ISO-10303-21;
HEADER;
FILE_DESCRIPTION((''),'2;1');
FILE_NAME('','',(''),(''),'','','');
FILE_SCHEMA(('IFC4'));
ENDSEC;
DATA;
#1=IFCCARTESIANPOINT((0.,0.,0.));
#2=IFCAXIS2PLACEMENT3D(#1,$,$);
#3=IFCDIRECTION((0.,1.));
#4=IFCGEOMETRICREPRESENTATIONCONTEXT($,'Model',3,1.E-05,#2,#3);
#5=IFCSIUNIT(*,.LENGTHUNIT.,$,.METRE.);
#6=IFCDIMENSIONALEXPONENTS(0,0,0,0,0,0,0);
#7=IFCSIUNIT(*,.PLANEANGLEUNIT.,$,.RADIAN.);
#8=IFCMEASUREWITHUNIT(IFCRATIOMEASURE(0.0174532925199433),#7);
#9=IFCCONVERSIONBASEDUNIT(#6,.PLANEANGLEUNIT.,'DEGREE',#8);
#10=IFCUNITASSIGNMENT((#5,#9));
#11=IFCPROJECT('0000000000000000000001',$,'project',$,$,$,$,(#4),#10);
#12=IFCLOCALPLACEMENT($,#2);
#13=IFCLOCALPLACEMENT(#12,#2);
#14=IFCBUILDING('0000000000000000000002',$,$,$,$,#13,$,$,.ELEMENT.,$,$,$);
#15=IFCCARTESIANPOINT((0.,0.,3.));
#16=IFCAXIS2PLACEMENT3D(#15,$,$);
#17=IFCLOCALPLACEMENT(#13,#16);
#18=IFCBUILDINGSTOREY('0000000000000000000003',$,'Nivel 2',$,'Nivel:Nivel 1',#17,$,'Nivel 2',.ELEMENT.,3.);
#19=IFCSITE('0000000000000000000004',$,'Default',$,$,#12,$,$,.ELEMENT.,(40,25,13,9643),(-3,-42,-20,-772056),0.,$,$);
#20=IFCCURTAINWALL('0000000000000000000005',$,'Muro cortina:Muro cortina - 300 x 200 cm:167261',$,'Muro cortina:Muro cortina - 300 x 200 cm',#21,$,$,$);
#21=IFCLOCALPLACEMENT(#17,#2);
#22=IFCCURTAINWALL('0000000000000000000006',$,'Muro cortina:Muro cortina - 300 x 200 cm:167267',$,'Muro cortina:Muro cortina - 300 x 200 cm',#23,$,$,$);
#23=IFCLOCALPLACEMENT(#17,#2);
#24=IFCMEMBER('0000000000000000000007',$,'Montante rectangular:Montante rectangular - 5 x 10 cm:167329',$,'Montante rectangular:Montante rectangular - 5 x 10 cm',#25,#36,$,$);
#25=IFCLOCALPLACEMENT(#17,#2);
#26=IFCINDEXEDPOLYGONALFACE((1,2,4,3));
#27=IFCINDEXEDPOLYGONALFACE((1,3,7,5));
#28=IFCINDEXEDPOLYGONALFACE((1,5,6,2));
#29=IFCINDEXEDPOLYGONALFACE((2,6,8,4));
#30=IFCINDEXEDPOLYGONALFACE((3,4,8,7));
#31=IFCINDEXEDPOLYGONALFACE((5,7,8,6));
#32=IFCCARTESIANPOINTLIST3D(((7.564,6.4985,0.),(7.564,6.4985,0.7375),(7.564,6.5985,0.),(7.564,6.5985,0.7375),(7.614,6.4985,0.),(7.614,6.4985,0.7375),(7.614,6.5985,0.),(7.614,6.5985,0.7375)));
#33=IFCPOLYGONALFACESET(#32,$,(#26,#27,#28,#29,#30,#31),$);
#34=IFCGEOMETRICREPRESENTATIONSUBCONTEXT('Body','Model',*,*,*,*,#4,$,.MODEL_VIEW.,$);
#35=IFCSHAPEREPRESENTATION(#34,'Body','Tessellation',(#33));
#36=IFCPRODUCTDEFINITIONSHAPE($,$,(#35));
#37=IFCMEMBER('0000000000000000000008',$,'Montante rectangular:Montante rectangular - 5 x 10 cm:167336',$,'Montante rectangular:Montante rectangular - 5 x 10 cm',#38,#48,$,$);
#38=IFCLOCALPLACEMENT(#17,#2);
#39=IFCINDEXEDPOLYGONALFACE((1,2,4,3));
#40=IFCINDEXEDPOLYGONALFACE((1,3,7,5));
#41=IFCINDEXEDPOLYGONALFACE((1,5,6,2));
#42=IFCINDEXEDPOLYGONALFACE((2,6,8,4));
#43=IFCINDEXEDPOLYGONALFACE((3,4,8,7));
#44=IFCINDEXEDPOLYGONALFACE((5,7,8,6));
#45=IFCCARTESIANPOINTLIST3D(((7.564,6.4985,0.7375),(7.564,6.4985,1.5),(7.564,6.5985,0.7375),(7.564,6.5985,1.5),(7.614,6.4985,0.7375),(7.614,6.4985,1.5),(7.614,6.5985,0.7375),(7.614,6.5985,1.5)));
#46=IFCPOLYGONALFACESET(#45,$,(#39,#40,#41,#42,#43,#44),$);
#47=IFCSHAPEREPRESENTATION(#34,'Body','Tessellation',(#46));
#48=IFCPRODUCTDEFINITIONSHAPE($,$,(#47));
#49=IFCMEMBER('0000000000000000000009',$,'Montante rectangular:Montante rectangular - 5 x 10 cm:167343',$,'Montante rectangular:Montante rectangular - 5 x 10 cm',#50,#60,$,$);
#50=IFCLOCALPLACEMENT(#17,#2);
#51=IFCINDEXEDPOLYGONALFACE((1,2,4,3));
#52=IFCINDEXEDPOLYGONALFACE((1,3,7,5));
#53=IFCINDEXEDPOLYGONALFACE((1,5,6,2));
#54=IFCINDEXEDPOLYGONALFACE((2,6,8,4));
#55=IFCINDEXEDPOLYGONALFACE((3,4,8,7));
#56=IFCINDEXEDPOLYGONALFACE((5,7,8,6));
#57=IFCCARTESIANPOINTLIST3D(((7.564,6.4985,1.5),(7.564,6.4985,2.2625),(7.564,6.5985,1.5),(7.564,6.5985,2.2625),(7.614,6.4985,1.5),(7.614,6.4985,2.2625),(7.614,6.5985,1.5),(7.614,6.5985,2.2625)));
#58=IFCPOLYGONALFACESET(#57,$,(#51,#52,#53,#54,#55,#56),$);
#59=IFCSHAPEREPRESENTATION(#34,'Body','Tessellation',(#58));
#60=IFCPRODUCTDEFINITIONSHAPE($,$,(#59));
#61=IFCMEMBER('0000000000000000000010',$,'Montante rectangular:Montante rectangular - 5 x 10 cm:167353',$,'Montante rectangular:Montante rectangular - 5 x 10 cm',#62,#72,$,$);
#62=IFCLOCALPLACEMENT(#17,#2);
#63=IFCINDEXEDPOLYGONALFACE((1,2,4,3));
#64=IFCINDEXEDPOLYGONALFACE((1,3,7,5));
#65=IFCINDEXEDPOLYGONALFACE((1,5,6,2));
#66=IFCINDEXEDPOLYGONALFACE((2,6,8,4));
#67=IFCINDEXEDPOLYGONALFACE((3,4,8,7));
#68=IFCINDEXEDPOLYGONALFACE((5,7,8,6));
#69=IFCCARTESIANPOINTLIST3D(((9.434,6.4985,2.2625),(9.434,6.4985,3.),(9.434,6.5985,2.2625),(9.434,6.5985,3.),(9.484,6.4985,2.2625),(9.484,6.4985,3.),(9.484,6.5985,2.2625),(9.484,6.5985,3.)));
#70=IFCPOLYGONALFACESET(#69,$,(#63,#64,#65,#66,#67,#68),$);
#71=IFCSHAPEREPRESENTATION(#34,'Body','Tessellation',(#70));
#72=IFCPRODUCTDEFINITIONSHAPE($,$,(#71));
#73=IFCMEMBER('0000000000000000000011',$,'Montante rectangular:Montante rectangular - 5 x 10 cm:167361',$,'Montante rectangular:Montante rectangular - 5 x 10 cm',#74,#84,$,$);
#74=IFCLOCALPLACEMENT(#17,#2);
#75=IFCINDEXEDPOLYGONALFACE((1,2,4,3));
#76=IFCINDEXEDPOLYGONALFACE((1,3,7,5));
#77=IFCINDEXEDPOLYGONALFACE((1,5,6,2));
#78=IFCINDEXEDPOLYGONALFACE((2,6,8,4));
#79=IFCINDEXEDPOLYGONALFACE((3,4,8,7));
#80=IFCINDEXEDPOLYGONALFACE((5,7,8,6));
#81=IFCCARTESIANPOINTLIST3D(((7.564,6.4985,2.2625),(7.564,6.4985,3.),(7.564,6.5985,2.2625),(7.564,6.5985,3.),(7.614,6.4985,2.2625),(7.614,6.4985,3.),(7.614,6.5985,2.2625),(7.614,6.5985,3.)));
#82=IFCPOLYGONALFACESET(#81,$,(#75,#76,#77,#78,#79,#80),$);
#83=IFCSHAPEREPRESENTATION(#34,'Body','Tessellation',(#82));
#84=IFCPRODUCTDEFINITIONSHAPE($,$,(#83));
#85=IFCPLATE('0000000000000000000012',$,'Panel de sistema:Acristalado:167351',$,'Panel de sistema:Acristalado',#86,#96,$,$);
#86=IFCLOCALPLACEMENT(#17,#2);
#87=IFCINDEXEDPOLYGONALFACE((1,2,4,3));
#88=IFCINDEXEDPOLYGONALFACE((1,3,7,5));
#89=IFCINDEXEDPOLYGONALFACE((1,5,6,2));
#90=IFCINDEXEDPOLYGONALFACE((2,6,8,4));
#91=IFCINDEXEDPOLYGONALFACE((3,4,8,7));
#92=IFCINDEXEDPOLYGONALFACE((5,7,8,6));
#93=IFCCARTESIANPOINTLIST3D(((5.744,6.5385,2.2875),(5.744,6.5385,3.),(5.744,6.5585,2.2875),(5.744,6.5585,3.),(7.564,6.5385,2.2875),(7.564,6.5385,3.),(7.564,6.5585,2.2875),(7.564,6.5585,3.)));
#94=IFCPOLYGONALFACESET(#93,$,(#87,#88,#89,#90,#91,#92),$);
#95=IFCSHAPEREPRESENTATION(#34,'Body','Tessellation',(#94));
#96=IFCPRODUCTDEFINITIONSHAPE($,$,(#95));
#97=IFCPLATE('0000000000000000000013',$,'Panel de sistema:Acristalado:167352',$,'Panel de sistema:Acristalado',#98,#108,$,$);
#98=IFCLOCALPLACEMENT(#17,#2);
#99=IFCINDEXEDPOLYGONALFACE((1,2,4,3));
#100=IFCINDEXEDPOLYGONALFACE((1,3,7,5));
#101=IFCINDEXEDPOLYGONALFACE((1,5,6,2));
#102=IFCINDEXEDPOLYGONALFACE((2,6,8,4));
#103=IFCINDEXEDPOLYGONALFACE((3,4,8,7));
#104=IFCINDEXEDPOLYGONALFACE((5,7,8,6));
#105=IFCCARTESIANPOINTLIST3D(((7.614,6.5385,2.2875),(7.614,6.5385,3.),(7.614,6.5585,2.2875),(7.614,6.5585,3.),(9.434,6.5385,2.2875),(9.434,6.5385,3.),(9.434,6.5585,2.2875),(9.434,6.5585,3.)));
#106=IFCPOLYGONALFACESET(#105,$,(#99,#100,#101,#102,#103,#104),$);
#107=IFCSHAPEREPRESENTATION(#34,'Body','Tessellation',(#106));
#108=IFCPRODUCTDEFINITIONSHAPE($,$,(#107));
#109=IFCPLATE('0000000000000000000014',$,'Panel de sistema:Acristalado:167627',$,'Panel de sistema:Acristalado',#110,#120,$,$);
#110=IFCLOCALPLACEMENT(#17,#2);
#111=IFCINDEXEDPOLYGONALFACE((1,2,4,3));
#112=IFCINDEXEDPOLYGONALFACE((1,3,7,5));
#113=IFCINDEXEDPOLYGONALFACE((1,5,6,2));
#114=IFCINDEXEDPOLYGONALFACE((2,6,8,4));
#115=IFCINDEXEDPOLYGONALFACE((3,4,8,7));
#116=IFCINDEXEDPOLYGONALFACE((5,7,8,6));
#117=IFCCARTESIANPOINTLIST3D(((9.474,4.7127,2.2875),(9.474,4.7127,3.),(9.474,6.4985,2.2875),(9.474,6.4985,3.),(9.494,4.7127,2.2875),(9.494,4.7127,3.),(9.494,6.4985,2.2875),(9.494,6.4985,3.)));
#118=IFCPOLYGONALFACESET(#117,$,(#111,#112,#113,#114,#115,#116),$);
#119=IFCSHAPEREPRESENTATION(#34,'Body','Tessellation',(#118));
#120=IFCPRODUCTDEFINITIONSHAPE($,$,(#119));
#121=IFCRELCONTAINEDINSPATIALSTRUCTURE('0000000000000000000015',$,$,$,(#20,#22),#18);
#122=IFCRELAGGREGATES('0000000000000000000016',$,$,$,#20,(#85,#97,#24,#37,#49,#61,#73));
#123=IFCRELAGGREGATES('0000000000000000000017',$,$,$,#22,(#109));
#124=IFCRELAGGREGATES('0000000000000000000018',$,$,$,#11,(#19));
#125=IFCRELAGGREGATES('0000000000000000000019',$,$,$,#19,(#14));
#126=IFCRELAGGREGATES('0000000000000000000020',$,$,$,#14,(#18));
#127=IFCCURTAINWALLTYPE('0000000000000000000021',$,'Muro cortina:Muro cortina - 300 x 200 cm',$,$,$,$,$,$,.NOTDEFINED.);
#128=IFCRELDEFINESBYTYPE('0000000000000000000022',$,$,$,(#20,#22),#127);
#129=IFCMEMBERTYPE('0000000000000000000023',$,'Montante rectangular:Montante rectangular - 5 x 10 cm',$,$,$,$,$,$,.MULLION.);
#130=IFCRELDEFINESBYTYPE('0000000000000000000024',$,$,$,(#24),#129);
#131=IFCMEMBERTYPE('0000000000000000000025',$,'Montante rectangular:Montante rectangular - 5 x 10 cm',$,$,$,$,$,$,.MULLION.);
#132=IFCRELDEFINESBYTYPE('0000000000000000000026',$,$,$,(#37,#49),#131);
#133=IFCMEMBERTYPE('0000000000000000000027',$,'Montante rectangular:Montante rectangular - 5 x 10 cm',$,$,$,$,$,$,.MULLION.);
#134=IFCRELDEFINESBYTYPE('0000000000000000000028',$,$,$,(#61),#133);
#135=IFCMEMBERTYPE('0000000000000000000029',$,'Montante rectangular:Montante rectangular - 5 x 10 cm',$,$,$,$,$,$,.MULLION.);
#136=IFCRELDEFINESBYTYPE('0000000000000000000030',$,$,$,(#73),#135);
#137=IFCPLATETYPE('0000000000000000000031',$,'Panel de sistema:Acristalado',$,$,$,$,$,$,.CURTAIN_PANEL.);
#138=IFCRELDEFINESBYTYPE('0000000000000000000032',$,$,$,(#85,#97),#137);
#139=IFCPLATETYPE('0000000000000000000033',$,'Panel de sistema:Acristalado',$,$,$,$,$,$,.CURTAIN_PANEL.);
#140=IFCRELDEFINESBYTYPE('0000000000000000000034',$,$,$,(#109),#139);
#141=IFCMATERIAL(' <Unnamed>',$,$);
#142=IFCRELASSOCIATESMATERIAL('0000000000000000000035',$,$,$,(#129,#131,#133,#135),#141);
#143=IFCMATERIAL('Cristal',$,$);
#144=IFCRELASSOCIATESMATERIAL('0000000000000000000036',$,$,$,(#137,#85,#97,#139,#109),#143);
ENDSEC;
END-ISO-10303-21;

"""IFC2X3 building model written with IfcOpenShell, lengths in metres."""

from ifc_helpers import new_model, entity, si_unit, converted_unit, direction, frame, origin, origin_2d_with_axis, place, context, subcontext, project, spatial, rectangle, extrude, source, transform, mapped, material, type_object, type_shapes, element, aggregate, save


model = new_model("IFC2X3")

# Units and contexts
model_context = context("Model", 3, precision=1e-05, world=origin(), true_north=direction((0.0, 1.0)))
body_context = subcontext(model_context, "Body", "Model", "MODEL_VIEW")
ifc_project = project(units=[si_unit("LENGTHUNIT", "METRE"), converted_unit("PLANEANGLEUNIT", "DEGREE", entity("IfcRatioMeasure", 0.0174532925199433), si_unit("PLANEANGLEUNIT", "RADIAN"), dimensions=[0, 0, 0, 0, 0, 0, 0])], contexts=[model_context])

# Site, building, storey
site_placement = place(None, origin())
site = spatial("IfcSite", under=ifc_project, at=site_placement, Name="Default", CompositionType="ELEMENT", RefLatitude=(40, 25, 13, 9643), RefLongitude=(-3, -42, -20, -772056), RefElevation=0.0)
building_placement = place(site_placement, origin())
building = spatial("IfcBuilding", under=site, at=building_placement, CompositionType="ELEMENT")
storey_placement = place(building_placement, frame((0.0, 0.0, 3.0)))
storey = spatial("IfcBuildingStorey", under=building, at=storey_placement, Name="Nivel 2", ObjectType="Nivel:Nivel 1", LongName="Nivel 2", CompositionType="ELEMENT", Elevation=3.0)

# Curtain walls
curtain_wall_type = type_object("IfcCurtainWallType", Name="Muro cortina:Muro cortina - 300 x 200 cm", PredefinedType="NOTDEFINED")
curtain_wall_1_placement = place(storey_placement, frame((0.0, 0.0, -3.0)))
curtain_wall_1 = element("IfcCurtainWall", 1, at=curtain_wall_1_placement, inside=storey, type_object=curtain_wall_type, Name="Muro cortina:Muro cortina - 300 x 200 cm:167261", ObjectType="Muro cortina:Muro cortina - 300 x 200 cm")
ifc_material_1 = material(Name=" <Unnamed>")
curtain_wall_2_placement = place(storey_placement, frame((0.0, 0.0, -3.0)))
curtain_wall_2 = element("IfcCurtainWall", 2, at=curtain_wall_2_placement, inside=storey, type_object=curtain_wall_type, Name="Muro cortina:Muro cortina - 300 x 200 cm:167267", ObjectType="Muro cortina:Muro cortina - 300 x 200 cm")

# Members
member_type_1 = type_object("IfcMemberType", Name="Montante rectangular:Montante rectangular - 5 x 10 cm", PredefinedType="MULLION", material=ifc_material_1)
shared_shape_1 = source(origin(), body_context, "Body", "SweptSolid", [
    extrude(rectangle(XDim=0.1, YDim=0.05, at=origin_2d_with_axis()), frame((0.0, 0.0, -0.7375), z_axis=(0.0, 0.0, 1.0), x_axis=(0.0, -1.0, 0.0)), (0.0, 0.0, 1.0), 0.7375),
])
type_shapes(member_type_1, [shared_shape_1])
member_1_placement = place(storey_placement, frame((7.589, 6.5485, 0.0), z_axis=(0.0, 0.0, -1.0), x_axis=(1.0, 0.0, 0.0)))
member_1 = element("IfcMember", 3, at=member_1_placement, type_object=member_type_1, Name="Montante rectangular:Montante rectangular - 5 x 10 cm:167329", ObjectType="Montante rectangular:Montante rectangular - 5 x 10 cm", context=body_context, shape_type="MappedRepresentation", body=[
    mapped(shared_shape_1, transform((0.0, 0.0, 0.0), scale=1.0)),
])
member_type_2 = type_object("IfcMemberType", Name="Montante rectangular:Montante rectangular - 5 x 10 cm", PredefinedType="MULLION", material=ifc_material_1)
shared_shape_2 = source(origin(), body_context, "Body", "SweptSolid", [
    extrude(rectangle(XDim=0.1, YDim=0.05, at=origin_2d_with_axis()), frame((0.0, 0.0, -0.7625), z_axis=(0.0, 0.0, 1.0), x_axis=(0.0, -1.0, 0.0)), (0.0, 0.0, 1.0), 0.7625),
])
type_shapes(member_type_2, [shared_shape_2])
member_2_placement = place(storey_placement, frame((7.589, 6.5485, 0.7375), z_axis=(0.0, 0.0, -1.0), x_axis=(1.0, 0.0, 0.0)))
member_2 = element("IfcMember", 4, at=member_2_placement, type_object=member_type_2, Name="Montante rectangular:Montante rectangular - 5 x 10 cm:167336", ObjectType="Montante rectangular:Montante rectangular - 5 x 10 cm", context=body_context, shape_type="MappedRepresentation", body=[
    mapped(shared_shape_2, transform((0.0, 0.0, 0.0), scale=1.0)),
])
member_3_placement = place(storey_placement, frame((7.589, 6.5485, 1.5), z_axis=(0.0, 0.0, -1.0), x_axis=(1.0, 0.0, 0.0)))
member_3 = element("IfcMember", 5, at=member_3_placement, type_object=member_type_2, Name="Montante rectangular:Montante rectangular - 5 x 10 cm:167343", ObjectType="Montante rectangular:Montante rectangular - 5 x 10 cm", context=body_context, shape_type="MappedRepresentation", body=[
    mapped(shared_shape_2, transform((0.0, 0.0, 0.0), scale=1.0)),
])
member_type_3 = type_object("IfcMemberType", Name="Montante rectangular:Montante rectangular - 5 x 10 cm", PredefinedType="MULLION", material=ifc_material_1)
shared_shape_3 = source(origin(), body_context, "Body", "SweptSolid", [
    extrude(rectangle(XDim=0.1, YDim=0.05, at=origin_2d_with_axis()), frame((-0.025, 0.0, -0.7375), z_axis=(0.0, 0.0, 1.0), x_axis=(0.0, -1.0, 0.0)), (0.0, 0.0, 1.0), 0.7375),
])
type_shapes(member_type_3, [shared_shape_3])
member_4_placement = place(storey_placement, frame((9.484, 6.5485, 2.2625), z_axis=(0.0, 0.0, -1.0), x_axis=(1.0, 0.0, 0.0)))
member_4 = element("IfcMember", 6, at=member_4_placement, type_object=member_type_3, Name="Montante rectangular:Montante rectangular - 5 x 10 cm:167353", ObjectType="Montante rectangular:Montante rectangular - 5 x 10 cm", context=body_context, shape_type="MappedRepresentation", body=[
    mapped(shared_shape_3, transform((0.0, 0.0, 0.0), scale=1.0)),
])
member_type_4 = type_object("IfcMemberType", Name="Montante rectangular:Montante rectangular - 5 x 10 cm", PredefinedType="MULLION", material=ifc_material_1)
shared_shape_4 = source(origin(), body_context, "Body", "SweptSolid", [
    extrude(rectangle(XDim=0.1, YDim=0.05, at=origin_2d_with_axis()), frame((0.0, 0.0, -0.7375), z_axis=(0.0, 0.0, 1.0), x_axis=(0.0, -1.0, 0.0)), (0.0, 0.0, 1.0), 0.7375),
])
type_shapes(member_type_4, [shared_shape_4])
member_5_placement = place(storey_placement, frame((7.589, 6.5485, 2.2625), z_axis=(0.0, 0.0, -1.0), x_axis=(1.0, 0.0, 0.0)))
member_5 = element("IfcMember", 7, at=member_5_placement, type_object=member_type_4, Name="Montante rectangular:Montante rectangular - 5 x 10 cm:167361", ObjectType="Montante rectangular:Montante rectangular - 5 x 10 cm", context=body_context, shape_type="MappedRepresentation", body=[
    mapped(shared_shape_4, transform((0.0, 0.0, 0.0), scale=1.0)),
])

# Plates
ifc_material_2 = material(Name="Cristal")
plate_type_1 = type_object("IfcPlateType", Name="Panel de sistema:Acristalado", PredefinedType="CURTAIN_PANEL", material=ifc_material_2)
shared_shape_5 = source(origin(), body_context, "Body", "SweptSolid", [
    extrude(rectangle(XDim=0.02, YDim=1.82, at=origin_2d_with_axis()), frame((0.0, 0.0, 0.0), z_axis=(0.0, 0.0, 1.0), x_axis=(0.0, 1.0, 0.0)), (0.0, 0.0, 1.0), 0.7125),
])
type_shapes(plate_type_1, [shared_shape_5])
plate_1_placement = place(curtain_wall_1_placement, frame((6.654, 6.5485, 5.2875)))
plate_1 = element("IfcPlate", 8, at=plate_1_placement, type_object=plate_type_1, material=ifc_material_2, Name="Panel de sistema:Acristalado:167351", ObjectType="Panel de sistema:Acristalado", context=body_context, shape_type="MappedRepresentation", body=[
    mapped(shared_shape_5, transform((0.0, 0.0, 0.0), scale=1.0)),
])
plate_2_placement = place(curtain_wall_1_placement, frame((8.524, 6.5485, 5.2875)))
plate_2 = element("IfcPlate", 9, at=plate_2_placement, type_object=plate_type_1, material=ifc_material_2, Name="Panel de sistema:Acristalado:167352", ObjectType="Panel de sistema:Acristalado", context=body_context, shape_type="MappedRepresentation", body=[
    mapped(shared_shape_5, transform((0.0, 0.0, 0.0), scale=1.0)),
])
aggregate(curtain_wall_1, [plate_1, plate_2, member_1, member_2, member_3, member_4, member_5])
plate_type_2 = type_object("IfcPlateType", Name="Panel de sistema:Acristalado", PredefinedType="CURTAIN_PANEL", material=ifc_material_2)
shared_shape_6 = source(origin(), body_context, "Body", "SweptSolid", [
    extrude(rectangle(XDim=0.02, YDim=1.7857, at=origin_2d_with_axis()), frame((0.0, 0.0, 0.0), z_axis=(0.0, 0.0, 1.0), x_axis=(0.0, 1.0, 0.0)), (0.0, 0.0, 1.0), 0.7125),
])
type_shapes(plate_type_2, [shared_shape_6])
plate_3_placement = place(curtain_wall_2_placement, frame((9.484, 5.6056, 5.2875), z_axis=(0.0, 0.0, 1.0), x_axis=(0.0, -1.0, 0.0)))
plate_3 = element("IfcPlate", 10, at=plate_3_placement, type_object=plate_type_2, material=ifc_material_2, Name="Panel de sistema:Acristalado:167627", ObjectType="Panel de sistema:Acristalado", context=body_context, shape_type="MappedRepresentation", body=[
    mapped(shared_shape_6, transform((0.0, 0.0, 0.0), scale=1.0)),
])
aggregate(curtain_wall_2, [plate_3])

save(model, "model.ifc")
